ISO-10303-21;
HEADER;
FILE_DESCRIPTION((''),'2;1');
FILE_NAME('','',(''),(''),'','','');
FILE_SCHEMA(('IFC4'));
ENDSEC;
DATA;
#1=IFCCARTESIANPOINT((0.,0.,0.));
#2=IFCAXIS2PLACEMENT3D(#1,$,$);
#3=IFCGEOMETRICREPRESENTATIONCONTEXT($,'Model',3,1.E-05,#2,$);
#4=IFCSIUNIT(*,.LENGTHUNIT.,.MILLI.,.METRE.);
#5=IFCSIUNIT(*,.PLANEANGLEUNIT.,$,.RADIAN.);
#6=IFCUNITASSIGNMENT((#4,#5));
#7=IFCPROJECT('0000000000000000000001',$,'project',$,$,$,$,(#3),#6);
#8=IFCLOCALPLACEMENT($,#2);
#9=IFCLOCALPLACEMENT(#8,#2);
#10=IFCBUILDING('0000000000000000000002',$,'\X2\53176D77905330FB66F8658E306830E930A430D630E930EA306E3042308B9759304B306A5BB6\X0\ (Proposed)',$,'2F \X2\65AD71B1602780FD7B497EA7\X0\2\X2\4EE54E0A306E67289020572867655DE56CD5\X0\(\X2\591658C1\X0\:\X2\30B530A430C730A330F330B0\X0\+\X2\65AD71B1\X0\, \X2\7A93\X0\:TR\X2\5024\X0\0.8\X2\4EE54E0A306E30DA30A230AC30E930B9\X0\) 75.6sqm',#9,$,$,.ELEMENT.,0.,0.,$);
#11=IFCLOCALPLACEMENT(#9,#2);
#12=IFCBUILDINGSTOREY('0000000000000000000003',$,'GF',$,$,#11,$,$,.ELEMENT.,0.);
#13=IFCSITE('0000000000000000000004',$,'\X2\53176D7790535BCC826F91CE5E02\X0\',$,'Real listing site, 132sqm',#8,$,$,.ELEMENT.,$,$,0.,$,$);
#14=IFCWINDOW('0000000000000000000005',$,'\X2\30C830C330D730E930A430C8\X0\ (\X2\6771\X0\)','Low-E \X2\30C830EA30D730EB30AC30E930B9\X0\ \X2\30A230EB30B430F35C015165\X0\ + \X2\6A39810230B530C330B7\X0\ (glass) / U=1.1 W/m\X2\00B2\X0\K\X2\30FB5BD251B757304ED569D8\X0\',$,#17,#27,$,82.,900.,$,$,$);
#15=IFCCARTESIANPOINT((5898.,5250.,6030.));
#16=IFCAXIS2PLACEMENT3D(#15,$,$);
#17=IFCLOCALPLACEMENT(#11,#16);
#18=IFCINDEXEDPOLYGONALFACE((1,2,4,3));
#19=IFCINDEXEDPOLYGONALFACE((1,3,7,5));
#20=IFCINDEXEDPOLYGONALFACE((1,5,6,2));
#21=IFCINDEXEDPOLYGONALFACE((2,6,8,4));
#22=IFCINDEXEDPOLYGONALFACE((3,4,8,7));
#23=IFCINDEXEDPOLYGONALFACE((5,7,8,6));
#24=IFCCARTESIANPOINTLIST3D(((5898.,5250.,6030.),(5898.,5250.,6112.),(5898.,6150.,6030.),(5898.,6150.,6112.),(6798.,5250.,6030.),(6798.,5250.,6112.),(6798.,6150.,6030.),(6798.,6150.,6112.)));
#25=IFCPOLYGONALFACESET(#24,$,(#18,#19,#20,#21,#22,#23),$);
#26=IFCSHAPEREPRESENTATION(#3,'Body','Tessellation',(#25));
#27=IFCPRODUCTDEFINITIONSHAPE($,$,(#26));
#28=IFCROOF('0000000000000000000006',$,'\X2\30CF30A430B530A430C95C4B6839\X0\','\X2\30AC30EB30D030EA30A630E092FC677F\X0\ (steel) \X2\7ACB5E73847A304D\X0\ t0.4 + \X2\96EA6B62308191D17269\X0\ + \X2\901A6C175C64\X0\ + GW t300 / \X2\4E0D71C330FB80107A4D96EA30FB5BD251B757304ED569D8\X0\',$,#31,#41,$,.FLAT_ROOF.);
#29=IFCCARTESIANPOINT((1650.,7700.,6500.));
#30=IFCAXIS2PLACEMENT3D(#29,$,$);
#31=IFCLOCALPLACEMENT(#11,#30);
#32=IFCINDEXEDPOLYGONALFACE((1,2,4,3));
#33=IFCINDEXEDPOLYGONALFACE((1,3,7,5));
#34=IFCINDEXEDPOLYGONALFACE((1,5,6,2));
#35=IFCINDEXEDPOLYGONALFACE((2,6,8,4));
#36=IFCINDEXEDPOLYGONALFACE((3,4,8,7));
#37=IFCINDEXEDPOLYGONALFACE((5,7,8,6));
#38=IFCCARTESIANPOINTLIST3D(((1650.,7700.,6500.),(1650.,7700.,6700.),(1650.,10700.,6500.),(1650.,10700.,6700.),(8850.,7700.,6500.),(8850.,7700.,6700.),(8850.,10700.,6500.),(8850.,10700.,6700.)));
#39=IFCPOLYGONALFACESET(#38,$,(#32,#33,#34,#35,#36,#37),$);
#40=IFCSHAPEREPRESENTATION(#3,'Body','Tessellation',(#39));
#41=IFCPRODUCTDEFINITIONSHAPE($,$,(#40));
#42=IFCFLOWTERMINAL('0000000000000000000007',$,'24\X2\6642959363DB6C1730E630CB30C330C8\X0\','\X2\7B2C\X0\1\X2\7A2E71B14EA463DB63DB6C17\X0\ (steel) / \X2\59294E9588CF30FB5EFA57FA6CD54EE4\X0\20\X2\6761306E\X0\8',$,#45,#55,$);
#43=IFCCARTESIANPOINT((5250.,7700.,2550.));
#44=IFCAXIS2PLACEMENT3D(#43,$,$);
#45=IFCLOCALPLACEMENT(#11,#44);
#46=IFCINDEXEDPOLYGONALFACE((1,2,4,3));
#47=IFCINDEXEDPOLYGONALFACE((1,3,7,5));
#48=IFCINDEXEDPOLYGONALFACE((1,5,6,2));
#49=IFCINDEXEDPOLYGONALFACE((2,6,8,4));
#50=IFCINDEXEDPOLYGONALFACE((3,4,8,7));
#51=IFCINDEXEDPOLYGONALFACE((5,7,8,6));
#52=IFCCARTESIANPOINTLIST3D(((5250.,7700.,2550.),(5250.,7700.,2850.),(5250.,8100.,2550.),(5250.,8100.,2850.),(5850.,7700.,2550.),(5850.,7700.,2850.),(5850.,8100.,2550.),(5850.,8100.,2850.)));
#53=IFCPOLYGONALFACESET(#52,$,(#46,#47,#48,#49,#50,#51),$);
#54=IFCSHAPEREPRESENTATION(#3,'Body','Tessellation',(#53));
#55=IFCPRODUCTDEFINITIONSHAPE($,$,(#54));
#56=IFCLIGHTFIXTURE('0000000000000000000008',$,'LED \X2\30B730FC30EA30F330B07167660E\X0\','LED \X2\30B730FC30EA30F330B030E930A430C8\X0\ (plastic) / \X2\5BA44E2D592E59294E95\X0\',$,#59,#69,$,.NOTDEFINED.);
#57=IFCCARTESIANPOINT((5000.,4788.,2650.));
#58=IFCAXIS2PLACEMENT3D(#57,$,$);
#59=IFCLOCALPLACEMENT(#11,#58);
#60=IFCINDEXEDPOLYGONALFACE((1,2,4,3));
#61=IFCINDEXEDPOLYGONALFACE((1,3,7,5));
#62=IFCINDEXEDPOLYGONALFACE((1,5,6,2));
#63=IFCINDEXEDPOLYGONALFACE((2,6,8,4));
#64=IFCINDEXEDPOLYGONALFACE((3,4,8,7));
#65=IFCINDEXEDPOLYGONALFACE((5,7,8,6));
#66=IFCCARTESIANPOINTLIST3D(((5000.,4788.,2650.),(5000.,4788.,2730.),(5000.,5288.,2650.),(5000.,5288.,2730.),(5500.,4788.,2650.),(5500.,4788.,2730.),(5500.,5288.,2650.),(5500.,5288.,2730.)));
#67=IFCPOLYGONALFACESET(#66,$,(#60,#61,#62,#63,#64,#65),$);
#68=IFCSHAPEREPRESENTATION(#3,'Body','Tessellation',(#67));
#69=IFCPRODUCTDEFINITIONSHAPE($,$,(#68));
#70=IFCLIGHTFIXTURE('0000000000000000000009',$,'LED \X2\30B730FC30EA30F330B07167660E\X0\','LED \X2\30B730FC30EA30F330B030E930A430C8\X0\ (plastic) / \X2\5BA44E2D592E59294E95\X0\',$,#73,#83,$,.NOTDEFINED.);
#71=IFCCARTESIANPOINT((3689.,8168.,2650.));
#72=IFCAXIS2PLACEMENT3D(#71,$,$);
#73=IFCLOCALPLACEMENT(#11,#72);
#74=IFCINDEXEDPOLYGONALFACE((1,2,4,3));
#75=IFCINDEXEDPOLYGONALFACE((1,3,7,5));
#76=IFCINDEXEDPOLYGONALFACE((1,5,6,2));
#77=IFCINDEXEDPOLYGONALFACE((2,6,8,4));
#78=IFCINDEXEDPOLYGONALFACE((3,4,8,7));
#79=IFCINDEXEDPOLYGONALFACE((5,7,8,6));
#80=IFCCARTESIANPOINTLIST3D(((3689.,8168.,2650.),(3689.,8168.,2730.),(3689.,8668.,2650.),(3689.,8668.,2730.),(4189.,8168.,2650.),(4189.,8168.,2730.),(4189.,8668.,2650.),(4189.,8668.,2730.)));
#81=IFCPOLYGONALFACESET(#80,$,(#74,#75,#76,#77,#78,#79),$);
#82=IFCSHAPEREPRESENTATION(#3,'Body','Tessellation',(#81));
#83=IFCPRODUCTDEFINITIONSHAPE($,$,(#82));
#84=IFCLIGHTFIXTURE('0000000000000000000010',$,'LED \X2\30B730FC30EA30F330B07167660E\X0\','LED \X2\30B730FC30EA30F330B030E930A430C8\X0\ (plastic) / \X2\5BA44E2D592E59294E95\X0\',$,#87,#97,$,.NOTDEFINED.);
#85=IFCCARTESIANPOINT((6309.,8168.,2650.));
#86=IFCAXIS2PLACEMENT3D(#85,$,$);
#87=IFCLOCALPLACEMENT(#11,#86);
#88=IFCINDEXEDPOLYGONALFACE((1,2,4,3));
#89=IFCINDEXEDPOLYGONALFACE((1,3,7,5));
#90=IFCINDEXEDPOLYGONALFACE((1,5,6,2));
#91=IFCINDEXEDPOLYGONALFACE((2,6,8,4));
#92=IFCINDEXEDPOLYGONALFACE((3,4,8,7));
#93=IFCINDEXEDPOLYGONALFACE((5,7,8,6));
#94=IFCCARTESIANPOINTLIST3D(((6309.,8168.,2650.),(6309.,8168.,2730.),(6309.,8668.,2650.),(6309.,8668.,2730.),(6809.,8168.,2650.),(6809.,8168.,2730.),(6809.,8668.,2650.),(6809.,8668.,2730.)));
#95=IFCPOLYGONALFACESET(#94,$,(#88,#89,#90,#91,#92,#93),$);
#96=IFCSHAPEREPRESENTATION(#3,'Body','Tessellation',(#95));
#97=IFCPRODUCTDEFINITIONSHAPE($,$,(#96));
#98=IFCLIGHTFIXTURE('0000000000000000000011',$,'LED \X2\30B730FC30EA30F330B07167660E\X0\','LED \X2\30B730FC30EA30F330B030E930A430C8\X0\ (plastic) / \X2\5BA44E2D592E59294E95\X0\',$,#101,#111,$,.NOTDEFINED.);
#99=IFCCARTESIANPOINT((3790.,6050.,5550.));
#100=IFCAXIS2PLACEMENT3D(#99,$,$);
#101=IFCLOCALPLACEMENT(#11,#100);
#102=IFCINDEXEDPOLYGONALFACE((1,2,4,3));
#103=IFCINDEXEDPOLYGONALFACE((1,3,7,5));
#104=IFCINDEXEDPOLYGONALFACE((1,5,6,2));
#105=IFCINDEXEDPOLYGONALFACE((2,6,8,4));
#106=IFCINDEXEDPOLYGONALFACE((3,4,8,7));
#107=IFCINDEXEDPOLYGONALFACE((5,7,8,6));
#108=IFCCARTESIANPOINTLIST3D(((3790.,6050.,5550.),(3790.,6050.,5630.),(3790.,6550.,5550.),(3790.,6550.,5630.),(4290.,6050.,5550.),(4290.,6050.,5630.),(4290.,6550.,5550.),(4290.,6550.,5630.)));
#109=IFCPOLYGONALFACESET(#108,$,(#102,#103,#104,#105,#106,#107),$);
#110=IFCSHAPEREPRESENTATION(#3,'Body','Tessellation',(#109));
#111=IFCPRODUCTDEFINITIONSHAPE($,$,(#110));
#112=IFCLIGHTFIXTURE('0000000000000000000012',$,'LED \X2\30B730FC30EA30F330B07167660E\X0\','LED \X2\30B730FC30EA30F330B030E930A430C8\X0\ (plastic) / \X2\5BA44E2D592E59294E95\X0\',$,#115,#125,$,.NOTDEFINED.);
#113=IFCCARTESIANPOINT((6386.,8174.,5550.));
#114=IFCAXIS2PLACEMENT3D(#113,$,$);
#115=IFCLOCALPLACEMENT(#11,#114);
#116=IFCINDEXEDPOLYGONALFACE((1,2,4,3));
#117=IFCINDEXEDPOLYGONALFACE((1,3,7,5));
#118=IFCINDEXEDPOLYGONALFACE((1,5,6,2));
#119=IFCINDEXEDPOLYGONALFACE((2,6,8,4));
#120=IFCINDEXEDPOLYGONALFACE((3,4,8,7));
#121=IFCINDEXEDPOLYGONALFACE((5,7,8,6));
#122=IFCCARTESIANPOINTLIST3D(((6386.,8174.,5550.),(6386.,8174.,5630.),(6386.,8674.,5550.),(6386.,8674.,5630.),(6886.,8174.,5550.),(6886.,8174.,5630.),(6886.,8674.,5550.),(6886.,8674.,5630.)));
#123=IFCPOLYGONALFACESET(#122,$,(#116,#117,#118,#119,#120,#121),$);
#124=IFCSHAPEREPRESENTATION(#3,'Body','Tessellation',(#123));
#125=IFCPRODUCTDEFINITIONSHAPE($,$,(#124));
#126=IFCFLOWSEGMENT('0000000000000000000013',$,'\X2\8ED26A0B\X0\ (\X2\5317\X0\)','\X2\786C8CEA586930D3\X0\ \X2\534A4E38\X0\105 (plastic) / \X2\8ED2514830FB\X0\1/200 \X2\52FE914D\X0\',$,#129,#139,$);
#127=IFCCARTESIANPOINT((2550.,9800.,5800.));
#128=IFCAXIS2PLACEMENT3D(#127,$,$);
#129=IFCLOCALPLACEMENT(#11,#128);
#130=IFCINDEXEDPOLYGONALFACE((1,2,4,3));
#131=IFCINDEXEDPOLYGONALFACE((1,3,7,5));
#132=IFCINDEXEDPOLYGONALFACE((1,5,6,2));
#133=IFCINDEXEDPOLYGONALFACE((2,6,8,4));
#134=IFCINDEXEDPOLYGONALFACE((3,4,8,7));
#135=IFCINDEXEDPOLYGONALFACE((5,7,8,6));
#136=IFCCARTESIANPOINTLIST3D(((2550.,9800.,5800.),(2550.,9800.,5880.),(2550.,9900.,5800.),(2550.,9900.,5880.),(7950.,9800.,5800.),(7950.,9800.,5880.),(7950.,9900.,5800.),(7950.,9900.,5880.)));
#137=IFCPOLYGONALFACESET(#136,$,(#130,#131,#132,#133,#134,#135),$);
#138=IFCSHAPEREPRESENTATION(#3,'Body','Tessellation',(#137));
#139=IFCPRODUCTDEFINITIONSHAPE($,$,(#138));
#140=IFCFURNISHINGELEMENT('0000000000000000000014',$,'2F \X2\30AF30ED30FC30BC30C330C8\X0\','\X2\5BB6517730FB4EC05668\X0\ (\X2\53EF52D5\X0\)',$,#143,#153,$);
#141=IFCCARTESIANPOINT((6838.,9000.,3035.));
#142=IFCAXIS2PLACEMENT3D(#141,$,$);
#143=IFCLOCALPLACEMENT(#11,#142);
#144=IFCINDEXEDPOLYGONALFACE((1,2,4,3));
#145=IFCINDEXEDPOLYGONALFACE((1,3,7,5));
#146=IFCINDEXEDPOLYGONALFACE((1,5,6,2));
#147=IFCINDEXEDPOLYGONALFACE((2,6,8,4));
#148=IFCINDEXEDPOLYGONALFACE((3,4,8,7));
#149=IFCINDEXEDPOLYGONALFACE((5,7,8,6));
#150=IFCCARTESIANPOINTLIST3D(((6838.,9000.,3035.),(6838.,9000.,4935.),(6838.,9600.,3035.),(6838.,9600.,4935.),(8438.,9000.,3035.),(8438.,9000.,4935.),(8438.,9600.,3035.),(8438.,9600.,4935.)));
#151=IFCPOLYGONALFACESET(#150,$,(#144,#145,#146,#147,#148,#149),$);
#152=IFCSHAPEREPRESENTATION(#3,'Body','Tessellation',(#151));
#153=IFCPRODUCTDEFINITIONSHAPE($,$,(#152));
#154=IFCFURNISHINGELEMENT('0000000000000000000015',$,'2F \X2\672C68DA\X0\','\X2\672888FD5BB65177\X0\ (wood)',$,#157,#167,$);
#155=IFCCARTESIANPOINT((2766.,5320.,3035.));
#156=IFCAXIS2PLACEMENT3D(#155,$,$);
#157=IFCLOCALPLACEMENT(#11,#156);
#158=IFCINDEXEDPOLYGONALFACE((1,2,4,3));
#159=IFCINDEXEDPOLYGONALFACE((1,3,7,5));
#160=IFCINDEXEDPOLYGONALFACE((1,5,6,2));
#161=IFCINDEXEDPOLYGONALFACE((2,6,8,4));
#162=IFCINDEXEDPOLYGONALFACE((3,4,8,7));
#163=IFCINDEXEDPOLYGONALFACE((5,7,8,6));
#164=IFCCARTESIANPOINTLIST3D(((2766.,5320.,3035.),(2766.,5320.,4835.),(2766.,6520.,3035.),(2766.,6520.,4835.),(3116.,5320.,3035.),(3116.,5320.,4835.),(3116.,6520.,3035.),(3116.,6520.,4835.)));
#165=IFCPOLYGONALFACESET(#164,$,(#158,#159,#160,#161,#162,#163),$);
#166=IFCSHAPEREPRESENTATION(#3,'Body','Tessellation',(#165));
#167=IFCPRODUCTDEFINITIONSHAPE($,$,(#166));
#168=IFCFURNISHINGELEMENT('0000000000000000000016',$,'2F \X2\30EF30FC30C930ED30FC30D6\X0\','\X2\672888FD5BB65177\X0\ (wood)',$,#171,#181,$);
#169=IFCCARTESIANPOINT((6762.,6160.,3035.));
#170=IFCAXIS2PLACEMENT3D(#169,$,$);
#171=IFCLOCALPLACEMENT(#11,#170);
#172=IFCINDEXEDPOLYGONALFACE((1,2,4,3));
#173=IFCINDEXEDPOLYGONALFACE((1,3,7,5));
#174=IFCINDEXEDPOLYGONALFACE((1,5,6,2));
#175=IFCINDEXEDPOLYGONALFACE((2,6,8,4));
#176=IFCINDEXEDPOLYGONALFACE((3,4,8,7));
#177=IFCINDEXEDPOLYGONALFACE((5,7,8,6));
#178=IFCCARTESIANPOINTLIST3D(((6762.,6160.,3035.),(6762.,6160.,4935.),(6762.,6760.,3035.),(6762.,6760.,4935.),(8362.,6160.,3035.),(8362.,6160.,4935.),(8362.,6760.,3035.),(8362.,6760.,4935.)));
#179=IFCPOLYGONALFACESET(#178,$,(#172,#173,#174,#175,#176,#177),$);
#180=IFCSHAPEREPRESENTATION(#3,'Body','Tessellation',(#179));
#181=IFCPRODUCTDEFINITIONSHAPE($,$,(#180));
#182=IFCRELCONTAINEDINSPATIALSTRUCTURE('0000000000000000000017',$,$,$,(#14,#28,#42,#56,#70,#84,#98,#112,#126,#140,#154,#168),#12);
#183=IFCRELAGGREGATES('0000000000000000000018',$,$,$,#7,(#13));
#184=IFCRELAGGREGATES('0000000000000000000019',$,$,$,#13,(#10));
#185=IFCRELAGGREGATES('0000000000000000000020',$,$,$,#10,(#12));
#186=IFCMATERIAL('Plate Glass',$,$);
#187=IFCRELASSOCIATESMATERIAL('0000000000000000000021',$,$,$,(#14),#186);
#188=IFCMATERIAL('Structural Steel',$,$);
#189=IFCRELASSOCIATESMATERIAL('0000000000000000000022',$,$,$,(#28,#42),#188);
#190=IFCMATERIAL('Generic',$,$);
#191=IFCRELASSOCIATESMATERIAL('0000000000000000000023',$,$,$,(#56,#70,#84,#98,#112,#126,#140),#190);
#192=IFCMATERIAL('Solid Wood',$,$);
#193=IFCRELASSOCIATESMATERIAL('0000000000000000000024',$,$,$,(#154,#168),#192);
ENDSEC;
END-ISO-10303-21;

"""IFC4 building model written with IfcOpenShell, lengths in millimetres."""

from ifc_helpers import new_model, si_unit, frame, frame_2d, origin, place, context, project, spatial, rectangle, extrude, material, element, save


model = new_model("IFC4")

# Units and contexts
model_context = context("Model", 3, precision=1e-05, world=origin())
ifc_project = project(units=[si_unit("LENGTHUNIT", "METRE", prefix="MILLI"), si_unit("PLANEANGLEUNIT", "RADIAN")], contexts=[model_context])

# Site, building, storey
site_placement = place(None, origin())
site = spatial("IfcSite", under=ifc_project, at=site_placement, Name="北海道富良野市", ObjectType="Real listing site, 132sqm", CompositionType="ELEMENT", RefElevation=0.0)
building_placement = place(site_placement, origin())
building = spatial("IfcBuilding", under=site, at=building_placement, Name="北海道・書斎とライブラリのある静かな家 (Proposed)", ObjectType="2F 断熱性能等级2以上の木造在来工法(外壁:サイディング+断熱, 窓:TR値0.8以上のペアガラス) 75.6sqm", CompositionType="ELEMENT", ElevationOfRefHeight=0.0, ElevationOfTerrain=0.0)
storey_placement = place(building_placement, origin())
storey = spatial("IfcBuildingStorey", under=building, at=storey_placement, Name="GF", CompositionType="ELEMENT", Elevation=0.0)

# Shared definitions
ifc_material_1 = material(Name="Solid Wood")

# Shared definitions
ifc_material_2 = material(Name="Plate Glass")

# Window
window_1_placement = place(storey_placement, frame((5898.0, 5250.0, 6030.0)))
element("IfcWindow", 1, at=window_1_placement, inside=storey, material=ifc_material_2, Name="トップライト (東)", Description="Low-E トリプルガラス アルゴン封入 + 樹脂サッシ (glass) / U=1.1 W/m²K・寒冷地仕様", OverallHeight=82.0, OverallWidth=900.0, context=model_context, shape_type="SweptSolid", body=[
    extrude(rectangle(XDim=900.0, YDim=900.0, at=frame_2d((450.0, 450.0))), frame((5898.0, 5250.0, 6030.0)), (0.0, 0.0, 1.0), 82.0),
])

# Roof
ifc_material_3 = material(Name="Structural Steel")
roof_placement = place(storey_placement, frame((1650.0, 7700.0, 6500.0)))
element("IfcRoof", 2, at=roof_placement, inside=storey, material=ifc_material_3, Name="ハイサイド屋根", Description="ガルバリウム鋼板 (steel) 立平葺き t0.4 + 雪止め金物 + 通気層 + GW t300 / 不燃・耐積雪・寒冷地仕様", PredefinedType="FLAT_ROOF", context=model_context, shape_type="SweptSolid", body=[
    extrude(rectangle(XDim=7200.0, YDim=3000.0, at=frame_2d((3600.0, 1500.0))), frame((1650.0, 7700.0, 6500.0)), (0.0, 0.0, 1.0), 200.0),
])

# Flow terminal
flow_terminal_placement = place(storey_placement, frame((5250.0, 7700.0, 2550.0)))
element("IfcFlowTerminal", 3, at=flow_terminal_placement, inside=storey, material=ifc_material_3, Name="24時間換気ユニット", Description="第1種熱交換換気 (steel) / 天井裏・建基法令20条の8", context=model_context, shape_type="SweptSolid", body=[
    extrude(rectangle(XDim=600.0, YDim=400.0, at=frame_2d((300.0, 200.0))), frame((5250.0, 7700.0, 2550.0)), (0.0, 0.0, 1.0), 300.0),
])

# Light fixtures
ifc_material_4 = material(Name="Generic")
light_fixture_1_placement = place(storey_placement, frame((5000.0, 4788.0, 2650.0)))
element("IfcLightFixture", 4, at=light_fixture_1_placement, inside=storey, material=ifc_material_4, Name="LED シーリング照明", Description="LED シーリングライト (plastic) / 室中央天井", PredefinedType="NOTDEFINED", context=model_context, shape_type="SweptSolid", body=[
    extrude(rectangle(XDim=500.0, YDim=500.0, at=frame_2d((250.0, 250.0))), frame((5000.0, 4788.0, 2650.0)), (0.0, 0.0, 1.0), 80.0),
])
light_fixture_2_placement = place(storey_placement, frame((3689.0, 8168.0, 2650.0)))
element("IfcLightFixture", 5, at=light_fixture_2_placement, inside=storey, material=ifc_material_4, Name="LED シーリング照明", Description="LED シーリングライト (plastic) / 室中央天井", PredefinedType="NOTDEFINED", context=model_context, shape_type="SweptSolid", body=[
    extrude(rectangle(XDim=500.0, YDim=500.0, at=frame_2d((250.0, 250.0))), frame((3689.0, 8168.0, 2650.0)), (0.0, 0.0, 1.0), 80.0),
])
light_fixture_3_placement = place(storey_placement, frame((6309.0, 8168.0, 2650.0)))
element("IfcLightFixture", 6, at=light_fixture_3_placement, inside=storey, material=ifc_material_4, Name="LED シーリング照明", Description="LED シーリングライト (plastic) / 室中央天井", PredefinedType="NOTDEFINED", context=model_context, shape_type="SweptSolid", body=[
    extrude(rectangle(XDim=500.0, YDim=500.0, at=frame_2d((250.0, 250.0))), frame((6309.0, 8168.0, 2650.0)), (0.0, 0.0, 1.0), 80.0),
])
light_fixture_4_placement = place(storey_placement, frame((3790.0, 6050.0, 5550.0)))
element("IfcLightFixture", 7, at=light_fixture_4_placement, inside=storey, material=ifc_material_4, Name="LED シーリング照明", Description="LED シーリングライト (plastic) / 室中央天井", PredefinedType="NOTDEFINED", context=model_context, shape_type="SweptSolid", body=[
    extrude(rectangle(XDim=500.0, YDim=500.0, at=frame_2d((250.0, 250.0))), frame((3790.0, 6050.0, 5550.0)), (0.0, 0.0, 1.0), 80.0),
])
light_fixture_5_placement = place(storey_placement, frame((6386.0, 8174.0, 5550.0)))
element("IfcLightFixture", 8, at=light_fixture_5_placement, inside=storey, material=ifc_material_4, Name="LED シーリング照明", Description="LED シーリングライト (plastic) / 室中央天井", PredefinedType="NOTDEFINED", context=model_context, shape_type="SweptSolid", body=[
    extrude(rectangle(XDim=500.0, YDim=500.0, at=frame_2d((250.0, 250.0))), frame((6386.0, 8174.0, 5550.0)), (0.0, 0.0, 1.0), 80.0),
])

# Flow segment
flow_segment_placement = place(storey_placement, frame((2550.0, 9800.0, 5800.0)))
element("IfcFlowSegment", 9, at=flow_segment_placement, inside=storey, material=ifc_material_4, Name="軒樋 (北)", Description="硬質塩ビ 半丸105 (plastic) / 軒先・1/200 勾配", context=model_context, shape_type="SweptSolid", body=[
    extrude(rectangle(XDim=5400.0, YDim=100.0, at=frame_2d((2700.0, 50.0))), frame((2550.0, 9800.0, 5800.0)), (0.0, 0.0, 1.0), 80.0),
])

# Furnishing elements
furnishing_1_placement = place(storey_placement, frame((6838.0, 9000.0, 3035.0)))
element("IfcFurnishingElement", 10, at=furnishing_1_placement, inside=storey, material=ifc_material_4, Name="2F クローゼット", Description="家具・什器 (可動)", context=model_context, shape_type="SweptSolid", body=[
    extrude(rectangle(XDim=1600.0, YDim=600.0, at=frame_2d((800.0, 300.0))), frame((6838.0, 9000.0, 3035.0)), (0.0, 0.0, 1.0), 1900.0),
])
furnishing_2_placement = place(storey_placement, frame((2766.0, 5320.0, 3035.0)))
element("IfcFurnishingElement", 11, at=furnishing_2_placement, inside=storey, material=ifc_material_1, Name="2F 本棚", Description="木製家具 (wood)", context=model_context, shape_type="SweptSolid", body=[
    extrude(rectangle(XDim=350.0, YDim=1200.0, at=frame_2d((175.0, 600.0))), frame((2766.0, 5320.0, 3035.0)), (0.0, 0.0, 1.0), 1800.0),
])
furnishing_3_placement = place(storey_placement, frame((6762.0, 6160.0, 3035.0)))
element("IfcFurnishingElement", 12, at=furnishing_3_placement, inside=storey, material=ifc_material_1, Name="2F ワードローブ", Description="木製家具 (wood)", context=model_context, shape_type="SweptSolid", body=[
    extrude(rectangle(XDim=1600.0, YDim=600.0, at=frame_2d((800.0, 300.0))), frame((6762.0, 6160.0, 3035.0)), (0.0, 0.0, 1.0), 1900.0),
])

save(model, "model.ifc")
